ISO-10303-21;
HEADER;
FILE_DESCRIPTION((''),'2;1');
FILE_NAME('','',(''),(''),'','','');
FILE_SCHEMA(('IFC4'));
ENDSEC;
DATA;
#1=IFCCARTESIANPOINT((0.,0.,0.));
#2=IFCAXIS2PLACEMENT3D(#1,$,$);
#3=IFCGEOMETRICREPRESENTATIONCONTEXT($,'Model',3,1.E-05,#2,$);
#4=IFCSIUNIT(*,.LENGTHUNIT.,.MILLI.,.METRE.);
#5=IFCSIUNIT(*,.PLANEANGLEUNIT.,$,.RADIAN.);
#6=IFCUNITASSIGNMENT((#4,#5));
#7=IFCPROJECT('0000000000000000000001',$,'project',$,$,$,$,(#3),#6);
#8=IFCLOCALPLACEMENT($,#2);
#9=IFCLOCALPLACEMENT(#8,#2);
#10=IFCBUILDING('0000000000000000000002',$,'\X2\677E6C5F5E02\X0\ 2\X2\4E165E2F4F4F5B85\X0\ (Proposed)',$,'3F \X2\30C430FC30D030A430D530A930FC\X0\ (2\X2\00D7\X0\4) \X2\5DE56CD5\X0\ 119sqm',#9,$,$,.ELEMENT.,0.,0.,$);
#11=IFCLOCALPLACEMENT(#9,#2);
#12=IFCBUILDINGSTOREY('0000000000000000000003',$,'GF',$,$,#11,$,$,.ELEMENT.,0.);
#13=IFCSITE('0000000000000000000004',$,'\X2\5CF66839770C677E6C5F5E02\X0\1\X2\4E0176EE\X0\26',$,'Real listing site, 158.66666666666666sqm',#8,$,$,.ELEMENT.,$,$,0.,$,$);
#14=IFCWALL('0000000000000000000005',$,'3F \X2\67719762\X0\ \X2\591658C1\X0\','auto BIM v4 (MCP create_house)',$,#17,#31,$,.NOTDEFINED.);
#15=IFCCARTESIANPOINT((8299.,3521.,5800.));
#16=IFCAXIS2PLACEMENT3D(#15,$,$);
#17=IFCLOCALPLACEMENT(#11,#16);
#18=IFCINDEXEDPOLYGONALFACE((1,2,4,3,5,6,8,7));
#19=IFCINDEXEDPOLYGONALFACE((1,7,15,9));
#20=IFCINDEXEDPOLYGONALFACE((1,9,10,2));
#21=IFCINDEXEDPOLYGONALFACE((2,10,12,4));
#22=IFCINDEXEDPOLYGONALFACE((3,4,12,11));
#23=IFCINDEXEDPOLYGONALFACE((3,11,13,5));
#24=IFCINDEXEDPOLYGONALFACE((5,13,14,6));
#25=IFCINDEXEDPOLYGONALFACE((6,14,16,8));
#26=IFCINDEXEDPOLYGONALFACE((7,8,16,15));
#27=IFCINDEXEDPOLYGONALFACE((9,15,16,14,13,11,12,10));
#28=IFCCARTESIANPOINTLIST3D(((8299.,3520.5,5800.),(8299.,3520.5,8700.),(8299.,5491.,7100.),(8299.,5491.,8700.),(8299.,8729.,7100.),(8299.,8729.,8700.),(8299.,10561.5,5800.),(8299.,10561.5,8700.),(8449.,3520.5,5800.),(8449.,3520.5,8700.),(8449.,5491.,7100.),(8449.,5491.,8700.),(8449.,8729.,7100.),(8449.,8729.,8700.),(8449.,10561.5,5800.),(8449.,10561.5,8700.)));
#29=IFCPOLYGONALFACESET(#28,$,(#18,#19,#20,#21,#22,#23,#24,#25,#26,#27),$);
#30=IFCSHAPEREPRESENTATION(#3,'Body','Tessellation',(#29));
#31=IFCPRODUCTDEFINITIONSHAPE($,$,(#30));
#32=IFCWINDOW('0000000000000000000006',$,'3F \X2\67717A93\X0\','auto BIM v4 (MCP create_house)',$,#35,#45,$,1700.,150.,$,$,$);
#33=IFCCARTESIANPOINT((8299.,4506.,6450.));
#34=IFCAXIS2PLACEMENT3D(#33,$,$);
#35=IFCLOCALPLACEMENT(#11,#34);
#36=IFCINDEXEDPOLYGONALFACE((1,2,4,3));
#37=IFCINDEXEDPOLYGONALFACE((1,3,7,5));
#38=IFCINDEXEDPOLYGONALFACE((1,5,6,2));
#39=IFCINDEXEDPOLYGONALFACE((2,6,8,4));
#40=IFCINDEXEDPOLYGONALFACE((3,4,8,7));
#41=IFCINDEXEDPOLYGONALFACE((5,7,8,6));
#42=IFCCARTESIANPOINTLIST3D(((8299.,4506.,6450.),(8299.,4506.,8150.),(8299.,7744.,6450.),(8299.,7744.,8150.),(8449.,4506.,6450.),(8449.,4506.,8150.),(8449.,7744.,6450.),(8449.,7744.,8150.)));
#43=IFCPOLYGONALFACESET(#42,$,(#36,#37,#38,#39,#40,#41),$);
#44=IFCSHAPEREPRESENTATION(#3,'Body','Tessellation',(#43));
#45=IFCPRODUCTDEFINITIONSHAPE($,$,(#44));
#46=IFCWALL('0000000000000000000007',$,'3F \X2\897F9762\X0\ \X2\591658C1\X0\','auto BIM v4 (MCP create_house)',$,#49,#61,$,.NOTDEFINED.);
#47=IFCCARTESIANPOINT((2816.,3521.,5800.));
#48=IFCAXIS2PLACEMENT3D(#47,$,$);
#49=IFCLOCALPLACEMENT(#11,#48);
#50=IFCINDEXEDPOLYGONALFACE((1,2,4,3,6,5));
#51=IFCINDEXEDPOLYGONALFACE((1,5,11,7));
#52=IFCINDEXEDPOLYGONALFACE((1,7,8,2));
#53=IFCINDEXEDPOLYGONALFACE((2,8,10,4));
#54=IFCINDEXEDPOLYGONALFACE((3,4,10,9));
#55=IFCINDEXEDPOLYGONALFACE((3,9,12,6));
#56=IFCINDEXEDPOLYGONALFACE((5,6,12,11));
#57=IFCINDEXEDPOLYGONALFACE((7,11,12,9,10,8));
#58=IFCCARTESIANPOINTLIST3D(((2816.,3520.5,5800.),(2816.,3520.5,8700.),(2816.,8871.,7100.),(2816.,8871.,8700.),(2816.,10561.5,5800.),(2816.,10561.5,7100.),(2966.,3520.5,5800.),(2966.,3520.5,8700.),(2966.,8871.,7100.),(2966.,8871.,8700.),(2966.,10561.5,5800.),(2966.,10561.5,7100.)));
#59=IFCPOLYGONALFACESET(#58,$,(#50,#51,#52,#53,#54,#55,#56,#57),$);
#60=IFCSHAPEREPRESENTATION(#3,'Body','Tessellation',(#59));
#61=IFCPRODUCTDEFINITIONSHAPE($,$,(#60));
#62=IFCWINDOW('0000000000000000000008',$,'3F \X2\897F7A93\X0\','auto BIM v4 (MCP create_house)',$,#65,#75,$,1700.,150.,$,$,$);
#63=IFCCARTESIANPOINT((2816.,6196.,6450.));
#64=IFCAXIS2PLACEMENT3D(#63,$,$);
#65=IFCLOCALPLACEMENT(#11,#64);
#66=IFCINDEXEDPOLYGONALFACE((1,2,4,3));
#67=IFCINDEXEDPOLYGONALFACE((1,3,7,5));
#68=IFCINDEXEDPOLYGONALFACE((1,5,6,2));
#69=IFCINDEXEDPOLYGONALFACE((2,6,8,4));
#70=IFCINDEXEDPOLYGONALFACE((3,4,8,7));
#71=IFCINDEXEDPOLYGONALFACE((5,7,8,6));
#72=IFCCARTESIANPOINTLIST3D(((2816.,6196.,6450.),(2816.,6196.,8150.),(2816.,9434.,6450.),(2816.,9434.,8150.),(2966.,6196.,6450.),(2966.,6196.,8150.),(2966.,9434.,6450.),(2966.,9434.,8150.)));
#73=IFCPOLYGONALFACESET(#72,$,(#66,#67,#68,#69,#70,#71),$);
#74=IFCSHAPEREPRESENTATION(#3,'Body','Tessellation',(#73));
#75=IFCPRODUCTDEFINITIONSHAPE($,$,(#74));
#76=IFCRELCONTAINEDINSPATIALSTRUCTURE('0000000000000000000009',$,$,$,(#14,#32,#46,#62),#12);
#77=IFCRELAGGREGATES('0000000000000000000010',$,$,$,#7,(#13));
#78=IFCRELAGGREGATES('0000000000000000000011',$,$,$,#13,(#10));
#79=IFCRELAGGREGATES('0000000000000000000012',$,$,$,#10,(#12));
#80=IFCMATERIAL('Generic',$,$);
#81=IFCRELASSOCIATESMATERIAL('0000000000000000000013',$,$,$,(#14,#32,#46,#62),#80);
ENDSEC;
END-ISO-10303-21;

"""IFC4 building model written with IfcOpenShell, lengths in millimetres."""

from ifc_helpers import new_model, si_unit, frame, frame_2d, origin, place, context, project, spatial, rectangle, extrude, material, element, fill, save


model = new_model("IFC4")

# Units and contexts
model_context = context("Model", 3, precision=1e-05, world=origin())
ifc_project = project(units=[si_unit("LENGTHUNIT", "METRE", prefix="MILLI"), si_unit("PLANEANGLEUNIT", "RADIAN")], contexts=[model_context])

# Site, building, storey
site_placement = place(None, origin())
site = spatial("IfcSite", under=ifc_project, at=site_placement, Name="島根県松江市1丁目26", ObjectType="Real listing site, 158.66666666666666sqm", CompositionType="ELEMENT", RefElevation=0.0)
building_placement = place(site_placement, origin())
building = spatial("IfcBuilding", under=site, at=building_placement, Name="松江市 2世帯住宅 (Proposed)", ObjectType="3F ツーバイフォー (2×4) 工法 119sqm", CompositionType="ELEMENT", ElevationOfRefHeight=0.0, ElevationOfTerrain=0.0)
storey_placement = place(building_placement, origin())
storey = spatial("IfcBuildingStorey", under=building, at=storey_placement, Name="GF", CompositionType="ELEMENT", Elevation=0.0)

# Shared definitions
ifc_material = material(Name="Generic")

# Walls, openings, windows
wall_1_placement = place(storey_placement, frame((8299.0, 3521.0, 5800.0)))
wall_1 = element("IfcWall", 1, at=wall_1_placement, inside=storey, material=ifc_material, Name="3F 東面 外壁", Description="auto BIM v4 (MCP create_house)", PredefinedType="NOTDEFINED", context=model_context, shape_type="SweptSolid", body=[
    extrude(rectangle(XDim=150.0, YDim=7041.0, at=frame_2d((75.0, 3520.0))), frame((8299.0, 3521.0, 5800.0)), (0.0, 0.0, 1.0), 2900.0),
])
opening_1_placement = place(storey_placement, frame((8299.0, 4506.0, 6450.0)))
opening_1 = element("IfcOpeningElement", 2, at=opening_1_placement, cuts=wall_1, PredefinedType="NOTDEFINED", context=model_context, shape_type="SweptSolid", body=[
    extrude(rectangle(XDim=150.0, YDim=3238.0, at=frame_2d((75.0, 1619.0))), frame((8299.0, 4506.0, 6450.0)), (0.0, 0.0, 1.0), 1700.0),
])
window_1_placement = place(storey_placement, frame((8299.0, 4506.0, 6450.0)))
window_1 = element("IfcWindow", 3, at=window_1_placement, inside=storey, material=ifc_material, Name="3F 東窓", Description="auto BIM v4 (MCP create_house)", OverallHeight=1700.0, OverallWidth=150.0, context=model_context, shape_type="SweptSolid", body=[
    extrude(rectangle(XDim=150.0, YDim=3238.0, at=frame_2d((75.0, 1619.0))), frame((8299.0, 4506.0, 6450.0)), (0.0, 0.0, 1.0), 1700.0),
])
fill(opening_1, window_1)
wall_2_placement = place(storey_placement, frame((2816.0, 3521.0, 5800.0)))
wall_2 = element("IfcWall", 4, at=wall_2_placement, inside=storey, material=ifc_material, Name="3F 西面 外壁", Description="auto BIM v4 (MCP create_house)", PredefinedType="NOTDEFINED", context=model_context, shape_type="SweptSolid", body=[
    extrude(rectangle(XDim=150.0, YDim=7041.0, at=frame_2d((75.0, 3520.0))), frame((2816.0, 3521.0, 5800.0)), (0.0, 0.0, 1.0), 2900.0),
])
opening_2_placement = place(storey_placement, frame((2816.0, 6196.0, 6450.0)))
opening_2 = element("IfcOpeningElement", 5, at=opening_2_placement, cuts=wall_2, PredefinedType="NOTDEFINED", context=model_context, shape_type="SweptSolid", body=[
    extrude(rectangle(XDim=150.0, YDim=3238.0, at=frame_2d((75.0, 1619.0))), frame((2816.0, 6196.0, 6450.0)), (0.0, 0.0, 1.0), 1700.0),
])
window_2_placement = place(storey_placement, frame((2816.0, 6196.0, 6450.0)))
window_2 = element("IfcWindow", 6, at=window_2_placement, inside=storey, material=ifc_material, Name="3F 西窓", Description="auto BIM v4 (MCP create_house)", OverallHeight=1700.0, OverallWidth=150.0, context=model_context, shape_type="SweptSolid", body=[
    extrude(rectangle(XDim=150.0, YDim=3238.0, at=frame_2d((75.0, 1619.0))), frame((2816.0, 6196.0, 6450.0)), (0.0, 0.0, 1.0), 1700.0),
])
fill(opening_2, window_2)

save(model, "model.ifc")
